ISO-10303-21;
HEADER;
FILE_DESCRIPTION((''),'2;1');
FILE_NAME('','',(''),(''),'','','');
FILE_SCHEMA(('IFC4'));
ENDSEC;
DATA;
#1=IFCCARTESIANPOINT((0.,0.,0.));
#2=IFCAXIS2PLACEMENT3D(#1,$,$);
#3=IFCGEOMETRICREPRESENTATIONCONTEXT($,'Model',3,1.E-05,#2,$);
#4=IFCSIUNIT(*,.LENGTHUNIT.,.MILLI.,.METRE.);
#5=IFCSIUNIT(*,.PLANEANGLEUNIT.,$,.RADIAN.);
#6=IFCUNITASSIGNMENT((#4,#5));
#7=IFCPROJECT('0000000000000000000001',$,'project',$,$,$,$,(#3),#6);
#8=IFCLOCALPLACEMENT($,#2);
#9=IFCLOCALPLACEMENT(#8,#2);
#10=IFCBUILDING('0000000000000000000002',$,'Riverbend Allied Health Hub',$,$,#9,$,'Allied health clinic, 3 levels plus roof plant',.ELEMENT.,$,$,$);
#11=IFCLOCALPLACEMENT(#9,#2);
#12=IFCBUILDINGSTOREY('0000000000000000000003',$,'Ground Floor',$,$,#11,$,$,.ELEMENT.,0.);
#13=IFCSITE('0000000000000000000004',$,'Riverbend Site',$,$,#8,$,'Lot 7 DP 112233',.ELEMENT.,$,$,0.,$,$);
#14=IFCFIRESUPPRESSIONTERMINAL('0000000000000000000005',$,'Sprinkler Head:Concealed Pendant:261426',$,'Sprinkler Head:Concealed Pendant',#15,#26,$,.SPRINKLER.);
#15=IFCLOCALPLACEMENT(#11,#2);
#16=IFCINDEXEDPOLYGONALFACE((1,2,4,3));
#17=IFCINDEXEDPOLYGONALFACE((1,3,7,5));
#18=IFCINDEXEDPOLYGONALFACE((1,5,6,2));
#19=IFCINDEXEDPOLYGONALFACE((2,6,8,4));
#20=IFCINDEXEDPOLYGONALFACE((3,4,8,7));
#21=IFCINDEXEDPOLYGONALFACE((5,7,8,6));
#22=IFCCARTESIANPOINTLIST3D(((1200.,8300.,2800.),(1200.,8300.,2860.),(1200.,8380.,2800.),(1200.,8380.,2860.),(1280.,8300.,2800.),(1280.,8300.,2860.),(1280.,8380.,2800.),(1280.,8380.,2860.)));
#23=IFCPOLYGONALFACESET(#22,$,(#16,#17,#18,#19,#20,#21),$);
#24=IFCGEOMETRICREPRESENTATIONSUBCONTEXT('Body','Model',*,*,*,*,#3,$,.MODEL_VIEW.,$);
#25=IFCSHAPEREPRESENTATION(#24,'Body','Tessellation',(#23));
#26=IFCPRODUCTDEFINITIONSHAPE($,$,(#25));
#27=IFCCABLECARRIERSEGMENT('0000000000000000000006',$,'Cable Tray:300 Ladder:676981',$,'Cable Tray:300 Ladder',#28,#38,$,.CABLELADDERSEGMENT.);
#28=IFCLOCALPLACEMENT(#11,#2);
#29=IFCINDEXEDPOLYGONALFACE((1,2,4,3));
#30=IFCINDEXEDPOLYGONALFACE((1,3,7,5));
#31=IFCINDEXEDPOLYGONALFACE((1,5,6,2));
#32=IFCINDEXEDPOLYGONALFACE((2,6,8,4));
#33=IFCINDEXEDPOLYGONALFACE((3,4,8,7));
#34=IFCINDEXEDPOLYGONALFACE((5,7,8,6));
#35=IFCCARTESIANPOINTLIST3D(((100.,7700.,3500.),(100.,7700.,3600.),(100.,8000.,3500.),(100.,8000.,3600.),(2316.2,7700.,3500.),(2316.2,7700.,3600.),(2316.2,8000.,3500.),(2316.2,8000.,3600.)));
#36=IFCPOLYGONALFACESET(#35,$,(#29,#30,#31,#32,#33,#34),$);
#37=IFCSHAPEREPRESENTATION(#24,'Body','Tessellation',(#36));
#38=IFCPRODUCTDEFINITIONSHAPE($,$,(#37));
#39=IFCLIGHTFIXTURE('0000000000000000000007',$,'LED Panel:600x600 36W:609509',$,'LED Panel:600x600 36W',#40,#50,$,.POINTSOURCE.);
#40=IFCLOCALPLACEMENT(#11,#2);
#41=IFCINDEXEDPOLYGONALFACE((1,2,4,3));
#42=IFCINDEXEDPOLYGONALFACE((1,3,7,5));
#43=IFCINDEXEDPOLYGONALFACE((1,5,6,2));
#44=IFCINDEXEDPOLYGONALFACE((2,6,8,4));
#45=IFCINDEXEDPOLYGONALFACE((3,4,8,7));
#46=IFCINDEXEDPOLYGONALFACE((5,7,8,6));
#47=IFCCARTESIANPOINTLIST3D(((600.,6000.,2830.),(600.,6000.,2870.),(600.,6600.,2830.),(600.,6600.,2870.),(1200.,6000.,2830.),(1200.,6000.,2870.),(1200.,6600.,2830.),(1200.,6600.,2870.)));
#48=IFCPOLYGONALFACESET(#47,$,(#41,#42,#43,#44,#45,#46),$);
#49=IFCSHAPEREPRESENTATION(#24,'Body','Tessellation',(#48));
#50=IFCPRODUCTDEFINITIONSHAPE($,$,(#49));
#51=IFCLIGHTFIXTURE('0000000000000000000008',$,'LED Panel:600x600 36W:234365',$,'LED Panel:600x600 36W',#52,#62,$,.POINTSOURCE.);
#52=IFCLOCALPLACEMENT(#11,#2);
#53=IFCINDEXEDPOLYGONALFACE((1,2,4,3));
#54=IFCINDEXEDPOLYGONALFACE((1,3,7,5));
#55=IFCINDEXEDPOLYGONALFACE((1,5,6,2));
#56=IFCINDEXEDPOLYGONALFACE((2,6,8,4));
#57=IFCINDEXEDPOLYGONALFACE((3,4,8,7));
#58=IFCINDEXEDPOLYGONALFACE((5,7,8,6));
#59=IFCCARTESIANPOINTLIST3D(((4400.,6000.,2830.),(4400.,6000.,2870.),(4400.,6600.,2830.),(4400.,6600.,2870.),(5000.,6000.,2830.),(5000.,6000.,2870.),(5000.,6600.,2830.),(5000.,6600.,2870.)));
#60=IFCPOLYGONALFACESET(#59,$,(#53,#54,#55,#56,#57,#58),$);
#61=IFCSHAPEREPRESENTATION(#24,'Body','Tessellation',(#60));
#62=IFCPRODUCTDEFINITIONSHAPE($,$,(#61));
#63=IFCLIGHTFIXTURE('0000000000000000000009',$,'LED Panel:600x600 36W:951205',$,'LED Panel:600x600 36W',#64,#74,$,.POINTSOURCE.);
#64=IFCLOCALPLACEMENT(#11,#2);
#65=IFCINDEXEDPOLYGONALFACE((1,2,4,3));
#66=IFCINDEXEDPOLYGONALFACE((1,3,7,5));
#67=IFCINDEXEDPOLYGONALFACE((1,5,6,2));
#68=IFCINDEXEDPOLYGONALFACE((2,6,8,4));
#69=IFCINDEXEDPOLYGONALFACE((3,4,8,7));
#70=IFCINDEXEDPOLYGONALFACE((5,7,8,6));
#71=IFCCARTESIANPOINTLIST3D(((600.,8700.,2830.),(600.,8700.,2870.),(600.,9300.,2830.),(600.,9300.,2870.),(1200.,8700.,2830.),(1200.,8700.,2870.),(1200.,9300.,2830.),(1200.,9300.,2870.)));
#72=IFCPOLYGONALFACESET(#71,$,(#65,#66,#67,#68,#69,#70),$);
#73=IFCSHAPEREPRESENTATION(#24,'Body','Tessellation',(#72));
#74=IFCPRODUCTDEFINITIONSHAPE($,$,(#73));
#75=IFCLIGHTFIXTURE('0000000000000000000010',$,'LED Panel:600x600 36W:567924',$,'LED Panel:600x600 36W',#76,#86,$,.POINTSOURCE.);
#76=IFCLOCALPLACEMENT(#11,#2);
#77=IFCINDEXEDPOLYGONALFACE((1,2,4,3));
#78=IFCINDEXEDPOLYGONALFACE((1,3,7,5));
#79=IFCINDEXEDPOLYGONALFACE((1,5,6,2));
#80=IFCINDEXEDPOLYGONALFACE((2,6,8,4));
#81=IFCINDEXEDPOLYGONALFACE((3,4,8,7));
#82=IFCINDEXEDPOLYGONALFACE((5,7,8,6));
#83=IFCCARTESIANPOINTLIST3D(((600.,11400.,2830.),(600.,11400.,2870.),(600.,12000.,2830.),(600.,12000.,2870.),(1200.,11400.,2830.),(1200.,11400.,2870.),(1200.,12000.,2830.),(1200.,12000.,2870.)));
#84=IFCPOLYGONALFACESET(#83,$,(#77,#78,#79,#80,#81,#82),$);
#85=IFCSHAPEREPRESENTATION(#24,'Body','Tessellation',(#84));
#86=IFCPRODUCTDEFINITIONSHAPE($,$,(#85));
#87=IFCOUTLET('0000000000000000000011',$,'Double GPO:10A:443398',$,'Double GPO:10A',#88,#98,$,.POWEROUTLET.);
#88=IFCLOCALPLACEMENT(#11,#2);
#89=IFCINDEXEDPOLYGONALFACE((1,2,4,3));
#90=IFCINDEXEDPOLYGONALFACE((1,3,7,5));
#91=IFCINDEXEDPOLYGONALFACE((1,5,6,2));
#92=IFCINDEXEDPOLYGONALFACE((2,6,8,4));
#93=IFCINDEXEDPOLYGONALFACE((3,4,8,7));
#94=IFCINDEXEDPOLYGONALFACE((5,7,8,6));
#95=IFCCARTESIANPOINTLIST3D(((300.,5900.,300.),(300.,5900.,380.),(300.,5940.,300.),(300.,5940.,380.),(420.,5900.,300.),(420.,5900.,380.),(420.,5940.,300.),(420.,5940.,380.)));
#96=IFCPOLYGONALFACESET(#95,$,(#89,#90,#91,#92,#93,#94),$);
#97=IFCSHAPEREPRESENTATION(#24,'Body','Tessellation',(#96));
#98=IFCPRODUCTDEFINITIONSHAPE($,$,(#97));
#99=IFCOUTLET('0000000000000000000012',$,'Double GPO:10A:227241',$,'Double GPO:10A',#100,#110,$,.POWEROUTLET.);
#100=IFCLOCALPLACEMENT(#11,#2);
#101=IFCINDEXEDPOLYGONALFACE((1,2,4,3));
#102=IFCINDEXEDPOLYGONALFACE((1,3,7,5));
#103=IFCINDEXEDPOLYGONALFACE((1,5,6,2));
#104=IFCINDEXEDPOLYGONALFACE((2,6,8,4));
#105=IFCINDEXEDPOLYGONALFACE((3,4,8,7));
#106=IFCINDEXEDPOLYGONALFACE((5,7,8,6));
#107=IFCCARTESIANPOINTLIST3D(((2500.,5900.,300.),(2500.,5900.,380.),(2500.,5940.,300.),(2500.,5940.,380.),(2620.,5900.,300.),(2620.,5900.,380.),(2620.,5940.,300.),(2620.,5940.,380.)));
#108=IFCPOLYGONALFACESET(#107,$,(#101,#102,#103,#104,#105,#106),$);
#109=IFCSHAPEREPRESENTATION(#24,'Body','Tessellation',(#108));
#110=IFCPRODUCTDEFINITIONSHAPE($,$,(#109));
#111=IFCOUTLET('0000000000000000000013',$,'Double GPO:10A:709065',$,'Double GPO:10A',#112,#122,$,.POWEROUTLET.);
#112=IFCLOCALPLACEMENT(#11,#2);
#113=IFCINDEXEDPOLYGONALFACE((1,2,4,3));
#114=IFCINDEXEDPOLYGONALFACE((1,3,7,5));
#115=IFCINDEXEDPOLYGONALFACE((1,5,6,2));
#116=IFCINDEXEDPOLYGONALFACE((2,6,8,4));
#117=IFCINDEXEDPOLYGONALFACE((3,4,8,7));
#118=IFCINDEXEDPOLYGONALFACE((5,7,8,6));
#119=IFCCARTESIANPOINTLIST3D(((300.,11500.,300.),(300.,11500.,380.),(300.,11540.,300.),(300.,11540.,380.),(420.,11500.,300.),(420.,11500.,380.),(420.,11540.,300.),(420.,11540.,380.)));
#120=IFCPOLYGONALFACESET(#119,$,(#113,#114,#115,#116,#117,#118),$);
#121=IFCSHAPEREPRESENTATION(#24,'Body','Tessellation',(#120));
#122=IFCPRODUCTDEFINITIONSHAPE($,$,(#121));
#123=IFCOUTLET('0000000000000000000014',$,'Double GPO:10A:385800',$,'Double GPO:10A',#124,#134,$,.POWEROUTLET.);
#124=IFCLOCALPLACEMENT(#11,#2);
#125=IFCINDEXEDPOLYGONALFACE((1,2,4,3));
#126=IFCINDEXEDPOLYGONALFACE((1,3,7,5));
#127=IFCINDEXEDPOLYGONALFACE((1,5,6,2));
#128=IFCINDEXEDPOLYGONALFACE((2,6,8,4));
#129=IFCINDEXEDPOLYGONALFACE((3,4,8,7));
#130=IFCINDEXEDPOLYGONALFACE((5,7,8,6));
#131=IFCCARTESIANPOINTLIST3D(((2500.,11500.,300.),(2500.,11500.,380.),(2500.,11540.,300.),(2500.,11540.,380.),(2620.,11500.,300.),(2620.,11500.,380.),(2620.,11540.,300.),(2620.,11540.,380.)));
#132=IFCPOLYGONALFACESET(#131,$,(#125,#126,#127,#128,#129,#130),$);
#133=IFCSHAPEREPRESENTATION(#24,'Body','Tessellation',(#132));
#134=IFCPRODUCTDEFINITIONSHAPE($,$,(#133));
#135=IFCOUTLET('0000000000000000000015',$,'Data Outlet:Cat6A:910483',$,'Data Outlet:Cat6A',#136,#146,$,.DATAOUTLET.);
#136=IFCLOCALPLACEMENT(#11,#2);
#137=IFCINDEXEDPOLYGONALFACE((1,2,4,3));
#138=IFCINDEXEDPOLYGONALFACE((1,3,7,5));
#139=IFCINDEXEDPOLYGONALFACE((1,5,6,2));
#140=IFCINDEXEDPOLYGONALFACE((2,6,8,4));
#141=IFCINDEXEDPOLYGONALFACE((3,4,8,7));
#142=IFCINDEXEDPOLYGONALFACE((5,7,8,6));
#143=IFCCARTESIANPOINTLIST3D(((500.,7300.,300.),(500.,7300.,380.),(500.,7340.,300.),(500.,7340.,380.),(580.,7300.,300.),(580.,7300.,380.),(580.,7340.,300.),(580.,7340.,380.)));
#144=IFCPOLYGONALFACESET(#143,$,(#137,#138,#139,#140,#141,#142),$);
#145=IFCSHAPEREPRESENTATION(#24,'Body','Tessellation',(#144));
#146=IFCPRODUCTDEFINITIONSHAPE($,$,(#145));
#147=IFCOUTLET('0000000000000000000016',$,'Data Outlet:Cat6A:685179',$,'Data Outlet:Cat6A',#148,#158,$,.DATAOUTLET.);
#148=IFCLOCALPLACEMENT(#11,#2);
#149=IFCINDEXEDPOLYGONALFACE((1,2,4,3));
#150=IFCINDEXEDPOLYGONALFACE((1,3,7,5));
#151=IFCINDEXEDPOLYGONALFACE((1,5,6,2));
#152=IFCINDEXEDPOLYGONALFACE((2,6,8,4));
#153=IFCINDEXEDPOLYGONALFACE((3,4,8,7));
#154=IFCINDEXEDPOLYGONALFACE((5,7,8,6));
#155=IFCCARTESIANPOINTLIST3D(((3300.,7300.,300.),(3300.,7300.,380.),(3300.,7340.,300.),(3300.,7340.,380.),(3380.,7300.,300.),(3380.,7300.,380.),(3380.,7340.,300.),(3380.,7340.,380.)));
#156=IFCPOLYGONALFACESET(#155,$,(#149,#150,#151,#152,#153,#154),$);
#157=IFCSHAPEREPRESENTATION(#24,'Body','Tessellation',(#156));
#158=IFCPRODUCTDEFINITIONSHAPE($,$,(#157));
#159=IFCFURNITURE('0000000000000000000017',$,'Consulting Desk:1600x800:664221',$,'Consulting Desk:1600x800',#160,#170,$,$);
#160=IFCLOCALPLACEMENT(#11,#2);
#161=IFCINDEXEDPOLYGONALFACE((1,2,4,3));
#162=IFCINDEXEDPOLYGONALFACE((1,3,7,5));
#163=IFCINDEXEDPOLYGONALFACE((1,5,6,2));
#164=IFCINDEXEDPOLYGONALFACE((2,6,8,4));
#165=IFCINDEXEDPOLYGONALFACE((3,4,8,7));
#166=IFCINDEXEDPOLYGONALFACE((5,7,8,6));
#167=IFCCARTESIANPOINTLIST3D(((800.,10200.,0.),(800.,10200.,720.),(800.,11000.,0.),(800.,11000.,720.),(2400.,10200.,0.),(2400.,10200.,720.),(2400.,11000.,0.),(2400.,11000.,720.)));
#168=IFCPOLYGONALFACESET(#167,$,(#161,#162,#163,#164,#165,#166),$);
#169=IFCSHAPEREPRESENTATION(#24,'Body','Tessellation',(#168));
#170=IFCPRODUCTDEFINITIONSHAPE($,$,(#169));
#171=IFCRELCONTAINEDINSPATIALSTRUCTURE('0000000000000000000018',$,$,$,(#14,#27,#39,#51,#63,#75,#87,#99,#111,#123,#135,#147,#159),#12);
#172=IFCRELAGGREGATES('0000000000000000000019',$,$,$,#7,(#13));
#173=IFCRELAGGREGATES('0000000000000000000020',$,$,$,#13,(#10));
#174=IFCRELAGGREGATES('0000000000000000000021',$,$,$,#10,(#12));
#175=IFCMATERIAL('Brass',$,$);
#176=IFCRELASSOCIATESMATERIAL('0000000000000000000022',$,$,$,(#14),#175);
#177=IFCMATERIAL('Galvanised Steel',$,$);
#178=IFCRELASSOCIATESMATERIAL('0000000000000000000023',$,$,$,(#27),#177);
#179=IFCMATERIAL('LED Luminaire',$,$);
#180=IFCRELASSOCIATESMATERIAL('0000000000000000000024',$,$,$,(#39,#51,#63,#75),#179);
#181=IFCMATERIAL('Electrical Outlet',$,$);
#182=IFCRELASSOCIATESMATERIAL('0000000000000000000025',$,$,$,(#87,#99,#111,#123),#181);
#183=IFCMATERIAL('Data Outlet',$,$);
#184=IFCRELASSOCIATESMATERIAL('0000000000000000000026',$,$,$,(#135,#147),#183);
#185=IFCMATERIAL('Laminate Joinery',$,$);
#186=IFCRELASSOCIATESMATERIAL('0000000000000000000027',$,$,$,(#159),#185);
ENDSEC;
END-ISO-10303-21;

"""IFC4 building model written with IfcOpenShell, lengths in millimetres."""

from ifc_helpers import new_model, si_unit, frame, frame_2d, origin, place, context, subcontext, project, spatial, rectangle, extrude, material, element, save


model = new_model("IFC4")

# Units and contexts
model_context = context("Model", 3, precision=1e-05, world=origin())
body_context = subcontext(model_context, "Body", "Model", "MODEL_VIEW")
ifc_project = project(units=[si_unit("LENGTHUNIT", "METRE", prefix="MILLI"), si_unit("PLANEANGLEUNIT", "RADIAN")], contexts=[model_context])

# Site, building, storey
site_placement = place(None, origin())
site = spatial("IfcSite", under=ifc_project, at=site_placement, Name="Riverbend Site", LongName="Lot 7 DP 112233", CompositionType="ELEMENT", RefElevation=0.0)
building_placement = place(site_placement, origin())
building = spatial("IfcBuilding", under=site, at=building_placement, Name="Riverbend Allied Health Hub", LongName="Allied health clinic, 3 levels plus roof plant", CompositionType="ELEMENT")
storey_placement = place(building_placement, origin())
storey = spatial("IfcBuildingStorey", under=building, at=storey_placement, Name="Ground Floor", CompositionType="ELEMENT", Elevation=0.0)

# Shared definitions
ifc_material_1 = material(Name="Galvanised Steel")

# Fire suppression terminal
ifc_material_2 = material(Name="Brass")
fire_suppression_terminal_placement = place(storey_placement, frame((1200.0, 8300.0, 2800.0)))
element("IfcFireSuppressionTerminal", 1, at=fire_suppression_terminal_placement, inside=storey, material=ifc_material_2, Name="Sprinkler Head:Concealed Pendant:261426", ObjectType="Sprinkler Head:Concealed Pendant", PredefinedType="SPRINKLER", context=body_context, shape_type="SweptSolid", body=[
    extrude(rectangle(XDim=80.0, YDim=80.0, at=frame_2d((40.0, 40.0))), origin(), (0.0, 0.0, 1.0), 60.0),
])

# Cable carrier segment
cable_carrier_segment_placement = place(storey_placement, frame((100.0, 7700.0, 3500.0)))
element("IfcCableCarrierSegment", 2, at=cable_carrier_segment_placement, inside=storey, material=ifc_material_1, Name="Cable Tray:300 Ladder:676981", ObjectType="Cable Tray:300 Ladder", PredefinedType="CABLELADDERSEGMENT", context=body_context, shape_type="SweptSolid", body=[
    extrude(rectangle(XDim=2216.2, YDim=300.0, at=frame_2d((1108.1, 150.0))), origin(), (0.0, 0.0, 1.0), 100.0),
])

# Light fixtures
ifc_material_3 = material(Name="LED Luminaire")
for number, where, name in (
    (3, (600.0, 6000.0, 2830.0), "LED Panel:600x600 36W:609509"),
    (4, (4400.0, 6000.0, 2830.0), "LED Panel:600x600 36W:234365"),
    (5, (600.0, 8700.0, 2830.0), "LED Panel:600x600 36W:951205"),
    (6, (600.0, 11400.0, 2830.0), "LED Panel:600x600 36W:567924"),
):
    element("IfcLightFixture", number, at=place(storey_placement, frame(where)), inside=storey, material=ifc_material_3, Name=name, ObjectType="LED Panel:600x600 36W", PredefinedType="POINTSOURCE", context=body_context, shape_type="SweptSolid", body=[
        extrude(rectangle(XDim=600.0, YDim=600.0, at=frame_2d((300.0, 300.0))), origin(), (0.0, 0.0, 1.0), 40.0),
    ])

# Outlets
ifc_material_4 = material(Name="Electrical Outlet")
for number, where, name in (
    (7, (300.0, 5900.0, 300.0), "Double GPO:10A:443398"),
    (8, (2500.0, 5900.0, 300.0), "Double GPO:10A:227241"),
    (9, (300.0, 11500.0, 300.0), "Double GPO:10A:709065"),
    (10, (2500.0, 11500.0, 300.0), "Double GPO:10A:385800"),
):
    element("IfcOutlet", number, at=place(storey_placement, frame(where)), inside=storey, material=ifc_material_4, Name=name, ObjectType="Double GPO:10A", PredefinedType="POWEROUTLET", context=body_context, shape_type="SweptSolid", body=[
        extrude(rectangle(XDim=120.0, YDim=40.0, at=frame_2d((60.0, 20.0))), origin(), (0.0, 0.0, 1.0), 80.0),
    ])
ifc_material_5 = material(Name="Data Outlet")
for number, where, name in (
    (11, (500.0, 7300.0, 300.0), "Data Outlet:Cat6A:910483"),
    (12, (3300.0, 7300.0, 300.0), "Data Outlet:Cat6A:685179"),
):
    element("IfcOutlet", number, at=place(storey_placement, frame(where)), inside=storey, material=ifc_material_5, Name=name, ObjectType="Data Outlet:Cat6A", PredefinedType="DATAOUTLET", context=body_context, shape_type="SweptSolid", body=[
        extrude(rectangle(XDim=80.0, YDim=40.0, at=frame_2d((40.0, 20.0))), origin(), (0.0, 0.0, 1.0), 80.0),
    ])

# Furniture
ifc_material_6 = material(Name="Laminate Joinery")
furniture_placement = place(storey_placement, frame((800.0, 10200.0, 0.0)))
element("IfcFurniture", 13, at=furniture_placement, inside=storey, material=ifc_material_6, Name="Consulting Desk:1600x800:664221", ObjectType="Consulting Desk:1600x800", context=body_context, shape_type="SweptSolid", body=[
    extrude(rectangle(XDim=1600.0, YDim=800.0, at=frame_2d((800.0, 400.0))), origin(), (0.0, 0.0, 1.0), 720.0),
])

save(model, "model.ifc")
